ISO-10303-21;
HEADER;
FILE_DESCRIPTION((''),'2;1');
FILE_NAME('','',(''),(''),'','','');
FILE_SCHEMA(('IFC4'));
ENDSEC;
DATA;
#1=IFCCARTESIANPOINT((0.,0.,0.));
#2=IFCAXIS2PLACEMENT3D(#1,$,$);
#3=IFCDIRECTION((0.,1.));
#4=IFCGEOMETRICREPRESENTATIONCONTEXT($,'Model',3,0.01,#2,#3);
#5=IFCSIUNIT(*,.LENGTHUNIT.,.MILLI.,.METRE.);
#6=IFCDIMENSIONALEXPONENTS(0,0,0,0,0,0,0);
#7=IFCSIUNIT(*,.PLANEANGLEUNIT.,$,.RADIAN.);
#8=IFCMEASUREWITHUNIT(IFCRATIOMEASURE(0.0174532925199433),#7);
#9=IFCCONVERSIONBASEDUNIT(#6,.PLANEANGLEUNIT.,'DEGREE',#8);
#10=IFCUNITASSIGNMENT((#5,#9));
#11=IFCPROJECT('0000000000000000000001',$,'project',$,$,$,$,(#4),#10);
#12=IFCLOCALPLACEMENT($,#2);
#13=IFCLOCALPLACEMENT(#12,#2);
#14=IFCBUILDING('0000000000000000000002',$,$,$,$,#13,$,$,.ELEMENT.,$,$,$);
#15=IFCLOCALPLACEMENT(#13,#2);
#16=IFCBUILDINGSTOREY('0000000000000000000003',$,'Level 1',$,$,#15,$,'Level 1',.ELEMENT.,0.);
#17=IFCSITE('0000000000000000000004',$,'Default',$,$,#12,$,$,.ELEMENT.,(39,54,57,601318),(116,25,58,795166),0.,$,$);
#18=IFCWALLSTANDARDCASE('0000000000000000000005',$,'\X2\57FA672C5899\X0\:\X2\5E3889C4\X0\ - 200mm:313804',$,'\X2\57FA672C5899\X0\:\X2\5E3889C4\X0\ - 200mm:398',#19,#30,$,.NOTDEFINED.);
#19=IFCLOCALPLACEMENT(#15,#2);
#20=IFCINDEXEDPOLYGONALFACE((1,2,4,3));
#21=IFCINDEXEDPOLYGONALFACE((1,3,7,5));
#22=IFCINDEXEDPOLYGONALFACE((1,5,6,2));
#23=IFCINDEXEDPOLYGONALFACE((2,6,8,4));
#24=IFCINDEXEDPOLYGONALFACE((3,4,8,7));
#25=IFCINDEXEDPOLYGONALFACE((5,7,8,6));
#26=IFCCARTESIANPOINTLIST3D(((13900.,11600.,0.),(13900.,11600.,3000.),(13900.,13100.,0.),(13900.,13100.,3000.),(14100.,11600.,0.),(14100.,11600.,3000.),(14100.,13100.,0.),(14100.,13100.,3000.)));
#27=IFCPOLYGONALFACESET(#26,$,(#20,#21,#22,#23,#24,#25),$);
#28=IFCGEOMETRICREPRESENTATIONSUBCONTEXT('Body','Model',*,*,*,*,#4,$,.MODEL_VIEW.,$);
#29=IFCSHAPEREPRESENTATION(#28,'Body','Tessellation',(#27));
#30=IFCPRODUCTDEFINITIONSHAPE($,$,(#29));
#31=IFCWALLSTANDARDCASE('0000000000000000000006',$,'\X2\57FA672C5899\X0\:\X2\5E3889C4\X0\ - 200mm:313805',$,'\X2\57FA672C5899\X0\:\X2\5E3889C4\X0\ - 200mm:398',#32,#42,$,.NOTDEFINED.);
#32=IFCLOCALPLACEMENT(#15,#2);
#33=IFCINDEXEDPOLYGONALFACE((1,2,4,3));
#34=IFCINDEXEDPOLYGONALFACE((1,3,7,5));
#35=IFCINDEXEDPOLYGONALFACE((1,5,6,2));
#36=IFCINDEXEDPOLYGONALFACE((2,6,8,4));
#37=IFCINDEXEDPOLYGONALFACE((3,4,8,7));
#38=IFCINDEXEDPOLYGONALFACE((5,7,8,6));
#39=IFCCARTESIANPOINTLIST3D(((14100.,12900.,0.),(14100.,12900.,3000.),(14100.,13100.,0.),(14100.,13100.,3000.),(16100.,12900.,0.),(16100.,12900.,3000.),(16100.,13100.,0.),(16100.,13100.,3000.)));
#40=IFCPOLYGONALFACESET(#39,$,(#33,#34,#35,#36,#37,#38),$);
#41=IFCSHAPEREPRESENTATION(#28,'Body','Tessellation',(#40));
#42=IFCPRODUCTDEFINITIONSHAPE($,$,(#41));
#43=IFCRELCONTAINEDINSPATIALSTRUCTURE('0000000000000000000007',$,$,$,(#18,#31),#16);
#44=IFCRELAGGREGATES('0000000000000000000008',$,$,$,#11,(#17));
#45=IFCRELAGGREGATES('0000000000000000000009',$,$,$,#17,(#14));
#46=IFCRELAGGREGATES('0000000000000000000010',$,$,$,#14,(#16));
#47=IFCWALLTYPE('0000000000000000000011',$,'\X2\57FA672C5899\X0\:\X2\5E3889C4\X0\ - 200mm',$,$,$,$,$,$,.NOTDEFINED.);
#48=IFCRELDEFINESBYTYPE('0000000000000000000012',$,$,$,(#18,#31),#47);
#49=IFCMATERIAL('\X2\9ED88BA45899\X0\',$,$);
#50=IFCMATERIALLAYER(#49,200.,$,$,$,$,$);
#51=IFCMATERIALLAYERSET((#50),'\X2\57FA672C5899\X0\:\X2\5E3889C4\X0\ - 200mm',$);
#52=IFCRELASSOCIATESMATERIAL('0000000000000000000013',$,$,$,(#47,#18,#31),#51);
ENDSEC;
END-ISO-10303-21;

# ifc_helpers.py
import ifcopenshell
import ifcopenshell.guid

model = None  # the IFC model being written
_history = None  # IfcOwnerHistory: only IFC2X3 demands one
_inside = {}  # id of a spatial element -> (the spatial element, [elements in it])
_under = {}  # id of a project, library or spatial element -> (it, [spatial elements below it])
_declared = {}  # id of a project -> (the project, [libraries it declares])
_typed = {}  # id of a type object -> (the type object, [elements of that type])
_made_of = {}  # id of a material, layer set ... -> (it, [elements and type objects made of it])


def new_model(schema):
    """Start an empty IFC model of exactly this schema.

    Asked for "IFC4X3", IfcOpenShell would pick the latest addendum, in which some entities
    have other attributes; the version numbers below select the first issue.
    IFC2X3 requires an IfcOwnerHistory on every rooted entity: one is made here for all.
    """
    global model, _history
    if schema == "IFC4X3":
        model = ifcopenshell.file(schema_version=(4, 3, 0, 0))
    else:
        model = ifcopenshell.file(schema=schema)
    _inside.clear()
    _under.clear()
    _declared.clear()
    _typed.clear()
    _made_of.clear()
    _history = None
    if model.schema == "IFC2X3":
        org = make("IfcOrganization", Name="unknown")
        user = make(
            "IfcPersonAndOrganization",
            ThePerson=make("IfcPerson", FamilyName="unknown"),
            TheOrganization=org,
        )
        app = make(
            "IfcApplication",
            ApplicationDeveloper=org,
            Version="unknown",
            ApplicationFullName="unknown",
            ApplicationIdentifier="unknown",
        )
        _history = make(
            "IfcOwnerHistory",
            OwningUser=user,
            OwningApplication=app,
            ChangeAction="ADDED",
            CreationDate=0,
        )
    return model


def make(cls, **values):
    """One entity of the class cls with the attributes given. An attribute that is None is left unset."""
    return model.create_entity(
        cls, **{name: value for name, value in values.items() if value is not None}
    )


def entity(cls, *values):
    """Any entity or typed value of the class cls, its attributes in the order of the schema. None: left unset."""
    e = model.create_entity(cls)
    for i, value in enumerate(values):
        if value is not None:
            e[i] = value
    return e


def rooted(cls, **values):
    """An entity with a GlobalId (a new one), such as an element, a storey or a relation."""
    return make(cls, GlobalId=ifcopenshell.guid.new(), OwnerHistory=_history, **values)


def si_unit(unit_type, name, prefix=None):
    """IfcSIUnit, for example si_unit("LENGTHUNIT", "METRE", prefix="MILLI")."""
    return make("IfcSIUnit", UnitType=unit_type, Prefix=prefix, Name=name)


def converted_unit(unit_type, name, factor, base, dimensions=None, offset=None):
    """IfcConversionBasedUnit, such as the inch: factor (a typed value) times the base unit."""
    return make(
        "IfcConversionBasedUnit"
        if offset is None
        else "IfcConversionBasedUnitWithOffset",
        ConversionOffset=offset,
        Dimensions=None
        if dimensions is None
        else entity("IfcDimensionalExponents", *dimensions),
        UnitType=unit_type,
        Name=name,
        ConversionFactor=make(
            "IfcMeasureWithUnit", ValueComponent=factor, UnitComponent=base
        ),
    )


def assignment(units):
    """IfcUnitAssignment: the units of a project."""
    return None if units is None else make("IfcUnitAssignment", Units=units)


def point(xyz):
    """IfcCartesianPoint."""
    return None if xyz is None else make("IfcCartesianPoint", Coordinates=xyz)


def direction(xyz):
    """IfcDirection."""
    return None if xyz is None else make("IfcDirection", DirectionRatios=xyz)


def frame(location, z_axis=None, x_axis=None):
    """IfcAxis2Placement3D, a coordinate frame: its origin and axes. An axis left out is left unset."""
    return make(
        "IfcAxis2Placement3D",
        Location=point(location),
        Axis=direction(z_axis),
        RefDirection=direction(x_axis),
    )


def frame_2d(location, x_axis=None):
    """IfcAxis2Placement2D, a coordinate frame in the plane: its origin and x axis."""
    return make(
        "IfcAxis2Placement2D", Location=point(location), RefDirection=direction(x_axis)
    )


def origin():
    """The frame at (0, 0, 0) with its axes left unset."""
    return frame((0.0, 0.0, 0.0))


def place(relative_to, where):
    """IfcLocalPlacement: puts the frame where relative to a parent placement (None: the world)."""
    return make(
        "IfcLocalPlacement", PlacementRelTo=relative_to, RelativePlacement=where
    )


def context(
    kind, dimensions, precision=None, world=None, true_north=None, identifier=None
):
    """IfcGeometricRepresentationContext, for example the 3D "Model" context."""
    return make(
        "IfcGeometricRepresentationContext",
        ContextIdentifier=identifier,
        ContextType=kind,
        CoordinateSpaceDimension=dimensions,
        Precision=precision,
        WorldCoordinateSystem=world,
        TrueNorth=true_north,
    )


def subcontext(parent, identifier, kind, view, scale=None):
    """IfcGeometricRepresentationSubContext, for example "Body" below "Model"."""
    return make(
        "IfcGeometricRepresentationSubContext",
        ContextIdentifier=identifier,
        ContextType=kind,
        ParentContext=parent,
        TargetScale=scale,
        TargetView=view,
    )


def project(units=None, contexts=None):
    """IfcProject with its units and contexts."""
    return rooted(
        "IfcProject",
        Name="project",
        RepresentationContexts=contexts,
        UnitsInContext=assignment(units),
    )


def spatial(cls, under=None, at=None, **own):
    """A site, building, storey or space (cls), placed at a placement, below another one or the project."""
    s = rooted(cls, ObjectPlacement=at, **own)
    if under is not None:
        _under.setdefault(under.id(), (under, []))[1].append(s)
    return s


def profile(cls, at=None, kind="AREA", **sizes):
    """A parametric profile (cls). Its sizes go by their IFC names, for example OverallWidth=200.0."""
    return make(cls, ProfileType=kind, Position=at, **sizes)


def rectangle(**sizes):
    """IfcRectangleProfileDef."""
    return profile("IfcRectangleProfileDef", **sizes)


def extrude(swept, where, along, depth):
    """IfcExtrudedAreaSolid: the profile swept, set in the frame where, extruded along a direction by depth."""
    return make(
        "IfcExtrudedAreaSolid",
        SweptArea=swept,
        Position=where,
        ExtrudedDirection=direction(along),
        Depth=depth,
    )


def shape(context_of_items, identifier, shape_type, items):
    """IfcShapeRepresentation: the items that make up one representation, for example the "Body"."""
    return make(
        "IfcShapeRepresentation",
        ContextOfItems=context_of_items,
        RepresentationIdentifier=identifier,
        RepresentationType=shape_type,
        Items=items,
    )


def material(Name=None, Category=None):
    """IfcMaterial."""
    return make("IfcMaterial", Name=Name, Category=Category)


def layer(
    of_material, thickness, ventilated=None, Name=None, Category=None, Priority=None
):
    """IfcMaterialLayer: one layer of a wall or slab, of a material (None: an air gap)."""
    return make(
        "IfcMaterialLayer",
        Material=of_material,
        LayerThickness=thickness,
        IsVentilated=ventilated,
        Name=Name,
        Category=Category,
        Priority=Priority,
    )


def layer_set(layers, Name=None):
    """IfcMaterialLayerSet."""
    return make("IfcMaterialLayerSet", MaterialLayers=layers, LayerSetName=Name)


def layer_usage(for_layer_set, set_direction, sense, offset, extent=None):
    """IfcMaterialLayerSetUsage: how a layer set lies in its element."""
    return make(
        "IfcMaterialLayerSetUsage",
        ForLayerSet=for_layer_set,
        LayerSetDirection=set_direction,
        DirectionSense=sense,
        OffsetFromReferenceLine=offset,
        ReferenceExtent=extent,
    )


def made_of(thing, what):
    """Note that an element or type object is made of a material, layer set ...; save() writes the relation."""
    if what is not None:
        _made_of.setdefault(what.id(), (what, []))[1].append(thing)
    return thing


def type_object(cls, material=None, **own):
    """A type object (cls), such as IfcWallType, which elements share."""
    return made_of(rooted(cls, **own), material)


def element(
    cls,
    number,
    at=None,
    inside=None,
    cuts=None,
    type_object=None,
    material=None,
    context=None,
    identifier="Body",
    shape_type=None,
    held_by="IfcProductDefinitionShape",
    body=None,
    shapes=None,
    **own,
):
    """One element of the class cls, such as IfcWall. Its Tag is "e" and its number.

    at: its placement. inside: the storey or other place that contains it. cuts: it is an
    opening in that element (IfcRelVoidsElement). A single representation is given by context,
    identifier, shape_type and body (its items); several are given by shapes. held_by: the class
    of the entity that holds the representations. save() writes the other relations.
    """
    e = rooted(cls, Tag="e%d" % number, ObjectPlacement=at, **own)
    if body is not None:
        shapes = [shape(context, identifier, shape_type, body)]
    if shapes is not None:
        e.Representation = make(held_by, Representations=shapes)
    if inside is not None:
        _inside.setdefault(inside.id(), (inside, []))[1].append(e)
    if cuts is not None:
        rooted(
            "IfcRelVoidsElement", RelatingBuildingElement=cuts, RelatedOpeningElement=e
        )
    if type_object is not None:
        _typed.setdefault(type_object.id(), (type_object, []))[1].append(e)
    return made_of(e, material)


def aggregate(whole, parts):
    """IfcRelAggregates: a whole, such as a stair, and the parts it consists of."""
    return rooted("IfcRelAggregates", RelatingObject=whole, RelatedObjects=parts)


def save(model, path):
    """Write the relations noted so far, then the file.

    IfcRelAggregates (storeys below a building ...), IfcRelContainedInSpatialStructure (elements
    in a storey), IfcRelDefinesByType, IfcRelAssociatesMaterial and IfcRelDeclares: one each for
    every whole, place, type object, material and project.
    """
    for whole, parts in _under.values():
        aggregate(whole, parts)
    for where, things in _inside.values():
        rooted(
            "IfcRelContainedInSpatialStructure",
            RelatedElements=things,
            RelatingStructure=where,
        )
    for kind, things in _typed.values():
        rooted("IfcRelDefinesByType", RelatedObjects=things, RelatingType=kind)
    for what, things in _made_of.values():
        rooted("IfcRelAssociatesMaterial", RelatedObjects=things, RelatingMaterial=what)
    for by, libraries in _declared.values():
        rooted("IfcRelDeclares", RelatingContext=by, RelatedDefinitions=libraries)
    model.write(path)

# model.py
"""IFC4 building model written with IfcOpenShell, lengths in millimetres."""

from ifc_helpers import new_model, entity, si_unit, converted_unit, direction, frame, frame_2d, origin, place, context, subcontext, project, spatial, rectangle, extrude, material, layer, layer_set, layer_usage, type_object, element, save


model = new_model("IFC4")

# Units and contexts
model_context = context("Model", 3, precision=0.01, world=origin(), true_north=direction((0.0, 1.0)))
body_context = subcontext(model_context, "Body", "Model", "MODEL_VIEW")
ifc_project = project(units=[si_unit("LENGTHUNIT", "METRE", prefix="MILLI"), converted_unit("PLANEANGLEUNIT", "DEGREE", entity("IfcRatioMeasure", 0.0174532925199433), si_unit("PLANEANGLEUNIT", "RADIAN"), dimensions=[0, 0, 0, 0, 0, 0, 0])], contexts=[model_context])

# Site, building, storey
site_placement = place(None, origin())
site = spatial("IfcSite", under=ifc_project, at=site_placement, Name="Default", CompositionType="ELEMENT", RefLatitude=(39, 54, 57, 601318), RefLongitude=(116, 25, 58, 795166), RefElevation=0.0)
building_placement = place(site_placement, origin())
building = spatial("IfcBuilding", under=site, at=building_placement, CompositionType="ELEMENT")
storey_placement = place(building_placement, origin())
storey = spatial("IfcBuildingStorey", under=building, at=storey_placement, Name="Level 1", LongName="Level 1", CompositionType="ELEMENT", Elevation=0.0)

# Shared definitions
ifc_material_1 = material(Name="默认墙")
ifc_layer = layer(ifc_material_1, 200.0)
ifc_layer_set = layer_set([ifc_layer], Name="基本墙:常规 - 200mm")
wall_type = type_object("IfcWallType", Name="基本墙:常规 - 200mm", PredefinedType="NOTDEFINED", material=ifc_layer_set)

# Walls
ifc_layer_usage_1 = layer_usage(ifc_layer_set, "AXIS2", "NEGATIVE", 100.0)
wall_1_placement = place(storey_placement, frame((14000.0, 11600.0, 0.0), z_axis=(0.0, 0.0, 1.0), x_axis=(0.0, 1.0, 0.0)))
element("IfcWallStandardCase", 1, at=wall_1_placement, inside=storey, type_object=wall_type, material=ifc_layer_usage_1, Name="基本墙:常规 - 200mm:313804", ObjectType="基本墙:常规 - 200mm:398", PredefinedType="NOTDEFINED", context=body_context, shape_type="SweptSolid", body=[
    extrude(rectangle(XDim=1500.0, YDim=200.0, at=frame_2d((750.0, 0.0), x_axis=(-1.0, 0.0))), origin(), (0.0, 0.0, 1.0), 3000.0),
])
ifc_layer_usage_2 = layer_usage(ifc_layer_set, "AXIS2", "NEGATIVE", 100.0)
wall_2_placement = place(storey_placement, frame((14100.0, 13000.0, 0.0)))
element("IfcWallStandardCase", 2, at=wall_2_placement, inside=storey, type_object=wall_type, material=ifc_layer_usage_2, Name="基本墙:常规 - 200mm:313805", ObjectType="基本墙:常规 - 200mm:398", PredefinedType="NOTDEFINED", context=body_context, shape_type="SweptSolid", body=[
    extrude(rectangle(XDim=2000.0, YDim=200.0, at=frame_2d((1000.0, 0.0), x_axis=(-1.0, 0.0))), origin(), (0.0, 0.0, 1.0), 3000.0),
])

save(model, "model.ifc")
